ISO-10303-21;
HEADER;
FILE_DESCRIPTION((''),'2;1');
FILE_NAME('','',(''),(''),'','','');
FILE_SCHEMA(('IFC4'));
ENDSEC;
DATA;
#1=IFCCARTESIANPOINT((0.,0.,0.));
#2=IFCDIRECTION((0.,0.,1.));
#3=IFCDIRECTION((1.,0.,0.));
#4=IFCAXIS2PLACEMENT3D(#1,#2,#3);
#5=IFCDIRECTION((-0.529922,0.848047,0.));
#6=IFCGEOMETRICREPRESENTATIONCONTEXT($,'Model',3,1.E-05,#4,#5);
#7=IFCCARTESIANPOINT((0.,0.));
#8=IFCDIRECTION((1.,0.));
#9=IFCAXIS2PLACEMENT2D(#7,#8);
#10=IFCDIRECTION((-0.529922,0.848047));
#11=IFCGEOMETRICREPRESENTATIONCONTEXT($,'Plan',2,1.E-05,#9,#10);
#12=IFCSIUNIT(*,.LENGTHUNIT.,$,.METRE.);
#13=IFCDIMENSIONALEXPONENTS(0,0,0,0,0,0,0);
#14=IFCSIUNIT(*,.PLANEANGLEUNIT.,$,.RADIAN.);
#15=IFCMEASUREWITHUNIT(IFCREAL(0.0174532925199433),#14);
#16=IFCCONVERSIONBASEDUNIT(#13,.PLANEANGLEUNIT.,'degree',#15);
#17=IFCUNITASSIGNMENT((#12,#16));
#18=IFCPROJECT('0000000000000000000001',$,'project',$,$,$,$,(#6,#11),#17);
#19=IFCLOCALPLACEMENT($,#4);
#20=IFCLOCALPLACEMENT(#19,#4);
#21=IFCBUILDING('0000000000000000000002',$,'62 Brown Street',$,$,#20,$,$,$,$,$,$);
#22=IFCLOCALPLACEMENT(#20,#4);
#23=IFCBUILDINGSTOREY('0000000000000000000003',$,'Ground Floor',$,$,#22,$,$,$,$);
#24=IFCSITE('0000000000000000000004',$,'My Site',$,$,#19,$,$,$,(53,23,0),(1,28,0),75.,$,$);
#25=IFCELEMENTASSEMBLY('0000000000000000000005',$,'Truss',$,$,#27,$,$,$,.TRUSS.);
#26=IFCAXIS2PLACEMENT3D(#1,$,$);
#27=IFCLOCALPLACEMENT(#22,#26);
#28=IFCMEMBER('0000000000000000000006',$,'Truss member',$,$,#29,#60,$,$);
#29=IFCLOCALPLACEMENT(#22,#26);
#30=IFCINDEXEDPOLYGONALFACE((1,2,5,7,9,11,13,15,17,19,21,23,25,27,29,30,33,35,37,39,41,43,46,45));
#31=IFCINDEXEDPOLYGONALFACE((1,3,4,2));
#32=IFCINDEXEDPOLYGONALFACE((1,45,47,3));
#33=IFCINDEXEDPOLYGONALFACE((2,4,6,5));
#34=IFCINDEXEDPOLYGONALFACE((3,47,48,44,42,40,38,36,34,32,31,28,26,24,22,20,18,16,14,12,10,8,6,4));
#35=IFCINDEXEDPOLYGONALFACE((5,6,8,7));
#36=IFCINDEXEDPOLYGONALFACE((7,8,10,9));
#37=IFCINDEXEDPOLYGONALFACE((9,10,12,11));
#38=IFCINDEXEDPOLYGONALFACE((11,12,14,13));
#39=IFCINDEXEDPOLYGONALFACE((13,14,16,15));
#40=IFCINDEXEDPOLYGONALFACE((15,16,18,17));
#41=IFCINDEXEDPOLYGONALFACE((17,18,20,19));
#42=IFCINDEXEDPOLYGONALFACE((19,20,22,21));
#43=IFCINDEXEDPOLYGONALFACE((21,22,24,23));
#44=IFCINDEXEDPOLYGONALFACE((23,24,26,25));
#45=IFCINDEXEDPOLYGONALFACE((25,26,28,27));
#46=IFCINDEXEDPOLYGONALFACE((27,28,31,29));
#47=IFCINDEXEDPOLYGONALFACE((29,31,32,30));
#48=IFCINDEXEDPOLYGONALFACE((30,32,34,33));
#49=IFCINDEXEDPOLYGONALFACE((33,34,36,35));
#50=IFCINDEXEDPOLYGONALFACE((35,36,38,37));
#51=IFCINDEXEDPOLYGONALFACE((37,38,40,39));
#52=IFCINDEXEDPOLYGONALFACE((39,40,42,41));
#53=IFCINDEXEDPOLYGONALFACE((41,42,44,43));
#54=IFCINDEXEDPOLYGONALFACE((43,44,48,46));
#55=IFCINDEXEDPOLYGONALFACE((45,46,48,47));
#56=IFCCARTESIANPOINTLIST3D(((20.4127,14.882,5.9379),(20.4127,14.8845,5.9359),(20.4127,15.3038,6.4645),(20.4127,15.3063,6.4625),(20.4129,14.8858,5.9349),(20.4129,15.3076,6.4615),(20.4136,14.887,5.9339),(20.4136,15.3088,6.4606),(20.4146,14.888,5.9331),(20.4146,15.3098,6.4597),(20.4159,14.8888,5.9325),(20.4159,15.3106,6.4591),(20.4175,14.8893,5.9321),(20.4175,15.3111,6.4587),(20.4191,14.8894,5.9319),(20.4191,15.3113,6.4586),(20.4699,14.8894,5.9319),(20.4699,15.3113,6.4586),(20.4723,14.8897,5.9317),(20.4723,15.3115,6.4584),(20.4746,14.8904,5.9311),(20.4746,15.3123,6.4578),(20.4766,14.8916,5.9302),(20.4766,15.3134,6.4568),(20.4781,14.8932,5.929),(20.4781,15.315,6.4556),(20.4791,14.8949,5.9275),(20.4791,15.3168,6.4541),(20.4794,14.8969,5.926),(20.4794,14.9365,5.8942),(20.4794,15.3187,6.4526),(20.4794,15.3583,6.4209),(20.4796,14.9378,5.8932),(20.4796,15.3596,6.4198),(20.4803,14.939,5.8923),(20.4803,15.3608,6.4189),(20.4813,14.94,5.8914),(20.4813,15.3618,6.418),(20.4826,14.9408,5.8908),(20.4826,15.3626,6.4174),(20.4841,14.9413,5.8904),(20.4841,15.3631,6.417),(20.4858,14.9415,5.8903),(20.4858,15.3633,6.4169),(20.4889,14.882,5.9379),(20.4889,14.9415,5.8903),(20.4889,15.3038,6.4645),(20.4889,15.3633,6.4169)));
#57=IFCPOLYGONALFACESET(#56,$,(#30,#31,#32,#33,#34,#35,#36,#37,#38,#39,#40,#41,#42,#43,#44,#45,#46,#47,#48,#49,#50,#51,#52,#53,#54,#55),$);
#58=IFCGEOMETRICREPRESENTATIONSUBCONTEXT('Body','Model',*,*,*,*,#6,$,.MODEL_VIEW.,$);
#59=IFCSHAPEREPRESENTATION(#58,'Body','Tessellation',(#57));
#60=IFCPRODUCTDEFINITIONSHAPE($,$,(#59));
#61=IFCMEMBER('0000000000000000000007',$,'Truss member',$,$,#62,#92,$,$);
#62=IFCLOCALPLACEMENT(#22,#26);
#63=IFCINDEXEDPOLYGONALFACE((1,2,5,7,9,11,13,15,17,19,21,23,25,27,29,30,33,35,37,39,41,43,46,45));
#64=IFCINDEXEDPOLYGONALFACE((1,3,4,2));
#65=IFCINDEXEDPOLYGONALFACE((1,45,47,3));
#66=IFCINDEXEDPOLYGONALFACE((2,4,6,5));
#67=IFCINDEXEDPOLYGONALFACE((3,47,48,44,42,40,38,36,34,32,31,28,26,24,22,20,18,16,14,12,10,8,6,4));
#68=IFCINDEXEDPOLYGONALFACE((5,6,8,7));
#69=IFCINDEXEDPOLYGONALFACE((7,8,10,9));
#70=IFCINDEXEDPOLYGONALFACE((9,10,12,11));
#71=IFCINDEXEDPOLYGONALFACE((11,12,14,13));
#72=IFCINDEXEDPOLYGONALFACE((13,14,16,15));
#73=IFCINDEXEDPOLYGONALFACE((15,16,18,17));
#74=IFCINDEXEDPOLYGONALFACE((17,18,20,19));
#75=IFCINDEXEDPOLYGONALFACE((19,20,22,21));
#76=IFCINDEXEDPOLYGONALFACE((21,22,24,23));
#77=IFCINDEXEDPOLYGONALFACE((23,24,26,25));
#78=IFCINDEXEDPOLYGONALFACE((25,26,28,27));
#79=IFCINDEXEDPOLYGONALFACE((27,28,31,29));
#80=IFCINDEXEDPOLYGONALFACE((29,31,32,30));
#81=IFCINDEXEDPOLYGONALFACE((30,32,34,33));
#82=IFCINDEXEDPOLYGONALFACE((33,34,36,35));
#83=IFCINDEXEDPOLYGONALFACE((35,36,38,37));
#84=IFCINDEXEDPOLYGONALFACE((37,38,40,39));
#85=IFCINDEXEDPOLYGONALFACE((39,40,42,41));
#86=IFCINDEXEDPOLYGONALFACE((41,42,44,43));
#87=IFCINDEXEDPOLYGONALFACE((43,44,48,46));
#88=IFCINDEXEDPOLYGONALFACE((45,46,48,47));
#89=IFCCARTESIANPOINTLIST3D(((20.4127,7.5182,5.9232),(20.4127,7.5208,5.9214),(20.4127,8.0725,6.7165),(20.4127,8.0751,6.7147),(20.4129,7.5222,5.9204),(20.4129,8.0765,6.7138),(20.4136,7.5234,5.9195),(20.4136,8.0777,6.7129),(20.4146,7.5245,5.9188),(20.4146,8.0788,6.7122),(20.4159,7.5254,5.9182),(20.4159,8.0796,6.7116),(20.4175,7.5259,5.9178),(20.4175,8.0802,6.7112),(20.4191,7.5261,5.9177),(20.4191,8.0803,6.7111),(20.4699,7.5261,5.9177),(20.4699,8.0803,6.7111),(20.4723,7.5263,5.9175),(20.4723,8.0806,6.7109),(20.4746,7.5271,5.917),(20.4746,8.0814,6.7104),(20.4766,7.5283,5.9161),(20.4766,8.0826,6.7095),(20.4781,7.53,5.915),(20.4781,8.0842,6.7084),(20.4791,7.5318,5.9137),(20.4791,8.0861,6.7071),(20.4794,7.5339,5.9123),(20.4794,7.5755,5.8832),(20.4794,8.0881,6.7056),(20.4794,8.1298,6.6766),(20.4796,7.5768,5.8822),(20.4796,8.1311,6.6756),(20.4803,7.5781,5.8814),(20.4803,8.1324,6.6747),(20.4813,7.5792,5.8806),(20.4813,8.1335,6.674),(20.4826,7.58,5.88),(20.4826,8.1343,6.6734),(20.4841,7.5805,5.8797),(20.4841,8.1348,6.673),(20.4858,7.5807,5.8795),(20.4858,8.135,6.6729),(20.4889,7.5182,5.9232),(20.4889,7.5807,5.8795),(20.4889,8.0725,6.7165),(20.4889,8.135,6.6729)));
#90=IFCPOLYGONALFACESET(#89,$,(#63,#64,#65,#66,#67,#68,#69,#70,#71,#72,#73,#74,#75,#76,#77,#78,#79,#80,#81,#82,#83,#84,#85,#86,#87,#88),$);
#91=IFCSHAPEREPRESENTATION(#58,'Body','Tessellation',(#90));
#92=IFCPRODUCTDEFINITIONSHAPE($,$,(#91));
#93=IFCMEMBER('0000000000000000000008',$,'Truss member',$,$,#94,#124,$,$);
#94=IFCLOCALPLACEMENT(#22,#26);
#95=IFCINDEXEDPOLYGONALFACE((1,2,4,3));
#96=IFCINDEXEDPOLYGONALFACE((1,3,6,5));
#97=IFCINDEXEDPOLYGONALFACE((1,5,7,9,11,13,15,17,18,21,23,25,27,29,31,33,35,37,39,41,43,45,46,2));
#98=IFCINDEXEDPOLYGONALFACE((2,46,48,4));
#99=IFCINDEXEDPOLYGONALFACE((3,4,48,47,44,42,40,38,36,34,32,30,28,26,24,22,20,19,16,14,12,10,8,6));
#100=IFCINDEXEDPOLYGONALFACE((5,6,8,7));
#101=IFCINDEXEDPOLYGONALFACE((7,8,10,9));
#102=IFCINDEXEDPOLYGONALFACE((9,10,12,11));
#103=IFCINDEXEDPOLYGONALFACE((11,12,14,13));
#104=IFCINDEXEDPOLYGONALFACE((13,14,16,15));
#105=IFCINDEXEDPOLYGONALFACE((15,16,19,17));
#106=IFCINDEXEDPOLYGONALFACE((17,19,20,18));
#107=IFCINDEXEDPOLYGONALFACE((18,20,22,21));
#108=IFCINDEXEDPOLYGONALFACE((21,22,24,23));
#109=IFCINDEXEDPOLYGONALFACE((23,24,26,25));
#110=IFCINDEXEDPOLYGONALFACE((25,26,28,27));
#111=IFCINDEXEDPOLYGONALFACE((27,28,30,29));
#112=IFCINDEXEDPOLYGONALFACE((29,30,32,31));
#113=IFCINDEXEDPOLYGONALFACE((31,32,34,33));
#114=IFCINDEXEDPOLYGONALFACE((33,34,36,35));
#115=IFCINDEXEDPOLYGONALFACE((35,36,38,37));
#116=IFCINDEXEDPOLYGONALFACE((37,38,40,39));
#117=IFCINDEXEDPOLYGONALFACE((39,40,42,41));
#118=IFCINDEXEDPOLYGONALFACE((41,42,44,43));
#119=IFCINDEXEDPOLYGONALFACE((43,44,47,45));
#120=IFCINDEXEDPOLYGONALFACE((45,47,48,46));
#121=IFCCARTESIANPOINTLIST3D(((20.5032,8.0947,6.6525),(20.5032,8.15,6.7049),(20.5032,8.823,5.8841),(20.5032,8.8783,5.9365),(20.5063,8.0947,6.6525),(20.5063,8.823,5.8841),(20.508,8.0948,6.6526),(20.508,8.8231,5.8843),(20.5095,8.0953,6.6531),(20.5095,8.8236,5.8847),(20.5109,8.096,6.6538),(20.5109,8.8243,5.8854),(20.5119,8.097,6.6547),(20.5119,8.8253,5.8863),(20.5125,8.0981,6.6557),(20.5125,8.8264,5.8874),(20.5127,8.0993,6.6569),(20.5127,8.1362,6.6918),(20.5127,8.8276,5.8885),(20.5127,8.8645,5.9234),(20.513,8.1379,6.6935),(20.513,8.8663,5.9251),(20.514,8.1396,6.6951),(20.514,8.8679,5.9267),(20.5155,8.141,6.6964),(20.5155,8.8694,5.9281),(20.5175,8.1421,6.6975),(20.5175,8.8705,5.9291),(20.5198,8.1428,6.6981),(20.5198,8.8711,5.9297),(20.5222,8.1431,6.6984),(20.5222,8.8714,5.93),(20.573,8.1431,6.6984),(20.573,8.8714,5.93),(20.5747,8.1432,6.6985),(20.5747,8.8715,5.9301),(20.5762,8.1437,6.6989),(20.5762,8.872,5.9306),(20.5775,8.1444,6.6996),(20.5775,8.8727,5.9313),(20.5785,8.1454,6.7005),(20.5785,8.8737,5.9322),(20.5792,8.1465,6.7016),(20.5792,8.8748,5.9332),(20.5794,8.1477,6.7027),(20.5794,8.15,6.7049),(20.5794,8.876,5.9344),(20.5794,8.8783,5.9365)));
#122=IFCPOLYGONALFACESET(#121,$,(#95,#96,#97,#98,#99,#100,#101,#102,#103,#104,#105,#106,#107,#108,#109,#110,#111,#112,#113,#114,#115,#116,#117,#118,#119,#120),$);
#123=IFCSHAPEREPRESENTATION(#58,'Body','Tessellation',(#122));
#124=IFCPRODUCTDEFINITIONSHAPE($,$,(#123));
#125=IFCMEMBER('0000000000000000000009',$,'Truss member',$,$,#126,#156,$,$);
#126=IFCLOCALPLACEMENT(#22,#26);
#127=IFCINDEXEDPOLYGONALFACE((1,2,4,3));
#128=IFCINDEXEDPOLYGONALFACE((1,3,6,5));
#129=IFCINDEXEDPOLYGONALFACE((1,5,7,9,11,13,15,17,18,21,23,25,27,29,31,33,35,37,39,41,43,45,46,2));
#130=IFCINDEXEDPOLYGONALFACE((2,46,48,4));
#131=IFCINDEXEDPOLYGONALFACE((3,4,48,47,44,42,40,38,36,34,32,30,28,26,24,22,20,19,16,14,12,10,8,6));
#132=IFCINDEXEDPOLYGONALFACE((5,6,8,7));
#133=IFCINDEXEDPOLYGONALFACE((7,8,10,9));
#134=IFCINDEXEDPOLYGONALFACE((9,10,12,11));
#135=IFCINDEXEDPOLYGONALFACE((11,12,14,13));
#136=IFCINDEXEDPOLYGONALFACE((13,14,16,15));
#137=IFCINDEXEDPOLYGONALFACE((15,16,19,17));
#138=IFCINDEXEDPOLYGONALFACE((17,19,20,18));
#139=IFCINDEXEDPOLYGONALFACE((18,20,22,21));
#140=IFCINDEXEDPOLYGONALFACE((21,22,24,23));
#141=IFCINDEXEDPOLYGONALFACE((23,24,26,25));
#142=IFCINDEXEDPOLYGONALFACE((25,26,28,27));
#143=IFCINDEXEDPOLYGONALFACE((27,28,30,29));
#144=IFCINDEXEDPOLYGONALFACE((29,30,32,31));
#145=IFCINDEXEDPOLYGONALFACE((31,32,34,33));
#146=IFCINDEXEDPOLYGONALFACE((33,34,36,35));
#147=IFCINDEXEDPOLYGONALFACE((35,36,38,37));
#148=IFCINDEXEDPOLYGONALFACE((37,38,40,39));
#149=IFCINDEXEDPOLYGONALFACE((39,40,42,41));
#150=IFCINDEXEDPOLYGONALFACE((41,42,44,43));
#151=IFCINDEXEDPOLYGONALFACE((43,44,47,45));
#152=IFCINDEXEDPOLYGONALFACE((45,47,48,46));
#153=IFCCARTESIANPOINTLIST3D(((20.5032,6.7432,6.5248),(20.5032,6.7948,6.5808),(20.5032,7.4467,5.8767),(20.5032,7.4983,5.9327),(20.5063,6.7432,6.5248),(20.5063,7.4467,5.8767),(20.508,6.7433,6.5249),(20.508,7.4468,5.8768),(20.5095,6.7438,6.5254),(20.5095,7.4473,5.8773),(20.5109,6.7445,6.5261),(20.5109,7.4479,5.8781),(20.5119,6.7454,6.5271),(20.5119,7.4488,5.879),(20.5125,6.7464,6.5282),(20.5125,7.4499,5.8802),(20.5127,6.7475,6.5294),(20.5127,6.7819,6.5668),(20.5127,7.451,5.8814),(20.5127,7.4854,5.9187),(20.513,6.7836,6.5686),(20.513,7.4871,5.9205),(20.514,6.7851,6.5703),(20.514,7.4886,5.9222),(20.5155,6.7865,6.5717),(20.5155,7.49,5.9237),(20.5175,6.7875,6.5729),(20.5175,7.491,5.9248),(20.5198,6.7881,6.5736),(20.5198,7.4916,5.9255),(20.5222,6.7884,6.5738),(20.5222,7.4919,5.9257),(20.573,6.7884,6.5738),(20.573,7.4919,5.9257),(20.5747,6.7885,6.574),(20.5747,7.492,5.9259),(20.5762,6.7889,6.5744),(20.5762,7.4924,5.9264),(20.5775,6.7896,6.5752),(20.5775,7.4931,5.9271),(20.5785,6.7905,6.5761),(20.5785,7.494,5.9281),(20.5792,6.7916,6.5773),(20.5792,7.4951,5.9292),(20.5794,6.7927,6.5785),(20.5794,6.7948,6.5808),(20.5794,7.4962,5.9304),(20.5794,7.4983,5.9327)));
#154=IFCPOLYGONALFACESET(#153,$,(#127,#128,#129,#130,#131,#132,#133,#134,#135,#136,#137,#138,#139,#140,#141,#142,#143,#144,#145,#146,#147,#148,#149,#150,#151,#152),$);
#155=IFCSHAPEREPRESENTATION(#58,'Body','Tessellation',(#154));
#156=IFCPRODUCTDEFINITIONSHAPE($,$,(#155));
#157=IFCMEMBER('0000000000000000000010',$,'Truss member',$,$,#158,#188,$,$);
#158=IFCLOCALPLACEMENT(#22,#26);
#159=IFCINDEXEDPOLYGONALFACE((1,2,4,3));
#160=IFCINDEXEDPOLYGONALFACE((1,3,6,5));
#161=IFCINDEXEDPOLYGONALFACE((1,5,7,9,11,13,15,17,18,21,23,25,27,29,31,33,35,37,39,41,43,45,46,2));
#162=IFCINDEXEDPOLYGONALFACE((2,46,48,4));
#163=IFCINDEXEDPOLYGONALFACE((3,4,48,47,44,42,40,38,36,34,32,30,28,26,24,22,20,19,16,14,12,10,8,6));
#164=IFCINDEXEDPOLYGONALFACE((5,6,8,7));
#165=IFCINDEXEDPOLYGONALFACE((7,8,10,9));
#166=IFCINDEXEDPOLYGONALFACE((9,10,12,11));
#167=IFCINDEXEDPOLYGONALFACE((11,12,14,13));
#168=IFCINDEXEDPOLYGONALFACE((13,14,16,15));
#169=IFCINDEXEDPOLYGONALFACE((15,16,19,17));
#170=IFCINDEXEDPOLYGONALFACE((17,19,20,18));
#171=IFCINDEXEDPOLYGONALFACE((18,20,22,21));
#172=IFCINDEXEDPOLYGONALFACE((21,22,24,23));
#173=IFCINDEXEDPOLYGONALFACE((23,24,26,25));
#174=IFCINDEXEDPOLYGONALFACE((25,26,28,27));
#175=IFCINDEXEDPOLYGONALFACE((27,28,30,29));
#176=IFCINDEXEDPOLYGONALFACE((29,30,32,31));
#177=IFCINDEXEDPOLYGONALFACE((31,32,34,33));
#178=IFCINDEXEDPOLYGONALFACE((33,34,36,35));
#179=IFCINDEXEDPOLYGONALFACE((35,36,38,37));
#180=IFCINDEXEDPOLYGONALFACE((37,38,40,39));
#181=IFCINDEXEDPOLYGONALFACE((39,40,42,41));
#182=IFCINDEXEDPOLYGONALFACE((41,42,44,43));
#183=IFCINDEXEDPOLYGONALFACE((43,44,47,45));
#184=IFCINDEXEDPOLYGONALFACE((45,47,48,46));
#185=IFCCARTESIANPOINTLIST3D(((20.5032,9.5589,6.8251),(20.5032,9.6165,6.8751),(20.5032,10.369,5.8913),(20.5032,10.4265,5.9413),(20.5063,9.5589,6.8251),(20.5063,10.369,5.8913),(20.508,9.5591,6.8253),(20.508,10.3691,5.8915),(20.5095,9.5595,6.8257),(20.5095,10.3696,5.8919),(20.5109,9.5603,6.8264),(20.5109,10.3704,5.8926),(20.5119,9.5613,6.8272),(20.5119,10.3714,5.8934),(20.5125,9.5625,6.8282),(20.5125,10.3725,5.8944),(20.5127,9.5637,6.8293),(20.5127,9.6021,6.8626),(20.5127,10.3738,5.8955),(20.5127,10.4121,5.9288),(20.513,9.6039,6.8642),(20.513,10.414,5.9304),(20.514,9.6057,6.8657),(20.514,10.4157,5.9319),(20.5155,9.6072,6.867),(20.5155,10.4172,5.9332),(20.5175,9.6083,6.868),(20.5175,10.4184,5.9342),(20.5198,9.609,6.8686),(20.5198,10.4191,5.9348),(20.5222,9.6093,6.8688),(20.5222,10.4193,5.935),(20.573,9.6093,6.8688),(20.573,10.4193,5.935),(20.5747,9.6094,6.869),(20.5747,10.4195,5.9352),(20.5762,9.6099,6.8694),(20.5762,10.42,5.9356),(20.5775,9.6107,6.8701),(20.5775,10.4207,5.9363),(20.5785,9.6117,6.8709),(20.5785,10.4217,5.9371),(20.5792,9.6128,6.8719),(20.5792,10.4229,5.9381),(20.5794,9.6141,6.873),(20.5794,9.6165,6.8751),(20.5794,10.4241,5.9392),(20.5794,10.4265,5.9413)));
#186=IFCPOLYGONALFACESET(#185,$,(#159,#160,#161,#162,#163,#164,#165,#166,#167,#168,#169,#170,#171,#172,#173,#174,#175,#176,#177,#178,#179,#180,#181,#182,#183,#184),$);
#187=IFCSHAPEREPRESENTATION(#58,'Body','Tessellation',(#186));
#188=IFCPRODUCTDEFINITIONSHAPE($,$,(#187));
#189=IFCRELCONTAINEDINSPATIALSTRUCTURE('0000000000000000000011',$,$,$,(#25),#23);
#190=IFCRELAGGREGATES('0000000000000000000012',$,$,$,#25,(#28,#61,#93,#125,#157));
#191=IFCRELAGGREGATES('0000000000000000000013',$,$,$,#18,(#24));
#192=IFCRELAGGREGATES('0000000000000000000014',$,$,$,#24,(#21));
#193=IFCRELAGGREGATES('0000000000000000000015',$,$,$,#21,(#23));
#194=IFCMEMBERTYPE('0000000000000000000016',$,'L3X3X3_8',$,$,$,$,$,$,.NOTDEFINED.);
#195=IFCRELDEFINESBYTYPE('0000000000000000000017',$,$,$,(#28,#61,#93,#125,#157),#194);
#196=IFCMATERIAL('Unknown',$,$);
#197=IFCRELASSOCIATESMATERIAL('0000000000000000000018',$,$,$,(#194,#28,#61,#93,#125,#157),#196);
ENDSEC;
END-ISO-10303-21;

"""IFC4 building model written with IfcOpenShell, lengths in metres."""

from ifc_helpers import new_model, entity, si_unit, converted_unit, direction, frame, origin_with_axes, origin_2d_with_axis, place, context, subcontext, project, spatial, l_section, extrude, material, material_profile, profile_set, profile_usage, type_object, element, aggregate, save


model = new_model("IFC4")

# Units and contexts
model_context = context("Model", 3, precision=1e-05, world=origin_with_axes(), true_north=direction((-0.529922, 0.848047, 0.0)))
plan_context = context("Plan", 2, precision=1e-05, world=origin_2d_with_axis(), true_north=direction((-0.529922, 0.848047)))
body_context_1 = subcontext(model_context, "Body", "Model", "MODEL_VIEW")
ifc_project = project(units=[si_unit("LENGTHUNIT", "METRE"), converted_unit("PLANEANGLEUNIT", "degree", entity("IfcReal", 0.0174532925199433), si_unit("PLANEANGLEUNIT", "RADIAN"), dimensions=[0, 0, 0, 0, 0, 0, 0])], contexts=[model_context, plan_context])

# Site, building, storey
site_placement = place(None, origin_with_axes())
site = spatial("IfcSite", under=ifc_project, at=site_placement, Name="My Site", RefLatitude=(53, 23, 0), RefLongitude=(1, 28, 0), RefElevation=75.0)
building_placement = place(site_placement, origin_with_axes())
building = spatial("IfcBuilding", under=site, at=building_placement, Name="62 Brown Street")
storey_placement = place(building_placement, origin_with_axes())
storey = spatial("IfcBuildingStorey", under=building, at=storey_placement, Name="Ground Floor")

# Element assembly, members
assembly_placement = place(storey_placement, frame((20.5032, 10.4288, 6.9738), z_axis=(0.0, 0.0, 1.0), x_axis=(1.0, 0.0, 0.0)))
assembly = element("IfcElementAssembly", 1, at=assembly_placement, inside=storey, Name="Truss", PredefinedType="TRUSS")
ifc_material_1 = material(Name="Unknown")
ifc_material_profile_1 = material_profile(ifc_material_1, l_section(Depth=0.0762, Width=0.0762, Thickness=0.0095, FilletRadius=0.0095, EdgeRadius=0.0064))
ifc_profile_set_1 = profile_set([ifc_material_profile_1])
member_type_1 = type_object("IfcMemberType", Name="L3X3X3_8", PredefinedType="NOTDEFINED", material=ifc_profile_set_1)
ifc_profile_usage_1 = profile_usage(ifc_profile_set_1, cardinal=5)
member_1_placement = place(assembly_placement, frame((-0.0524, 4.9048, -0.5331), z_axis=(0.000001, -0.625169, -0.780489), x_axis=(-1.0, -0.000001, 0.0)))
member_1 = element("IfcMember", 2, at=member_1_placement, type_object=member_type_1, material=ifc_profile_usage_1, Name="Truss member", context=body_context_1, shape_type="SweptSolid", body=[
    extrude(l_section(Depth=0.0762, Width=0.0762, Thickness=0.0095, FilletRadius=0.0095, EdgeRadius=0.0064), origin_with_axes(), (0.0, 0.0, 1.0), 0.6747),
])
ifc_profile_usage_2 = profile_usage(ifc_profile_set_1, cardinal=5)
member_2_placement = place(assembly_placement, frame((-0.0524, -2.325, -0.279), z_axis=(0.000001, -0.572709, -0.819759), x_axis=(-1.0, -0.000001, 0.0)))
member_2 = element("IfcMember", 3, at=member_2_placement, type_object=member_type_1, material=ifc_profile_usage_2, Name="Truss member", context=body_context_1, shape_type="SweptSolid", body=[
    extrude(l_section(Depth=0.0762, Width=0.0762, Thickness=0.0095, FilletRadius=0.0095, EdgeRadius=0.0064), origin_with_axes(), (0.0, 0.0, 1.0), 0.9678),
])
ifc_profile_usage_3 = profile_usage(ifc_profile_set_1, cardinal=5)
member_3_placement = place(assembly_placement, frame((0.0381, -2.3065, -0.2951), z_axis=(-0.000001, 0.687927, -0.72578), x_axis=(1.0, 0.0, 0.0)))
member_3 = element("IfcMember", 4, at=member_3_placement, type_object=member_type_1, material=ifc_profile_usage_3, Name="Truss member", context=body_context_1, shape_type="SweptSolid", body=[
    extrude(l_section(Depth=0.0762, Width=0.0762, Thickness=0.0095, FilletRadius=0.0095, EdgeRadius=0.0064), origin_with_axes(), (0.0, 0.0, 1.0), 1.0587),
])
ifc_profile_usage_4 = profile_usage(ifc_profile_set_1, cardinal=5)
member_4_placement = place(assembly_placement, frame((0.0381, -3.6598, -0.421), z_axis=(-0.000001, 0.735484, -0.677542), x_axis=(1.0, 0.000001, 0.0)))
member_4 = element("IfcMember", 5, at=member_4_placement, type_object=member_type_1, material=ifc_profile_usage_4, Name="Truss member", context=body_context_1, shape_type="SweptSolid", body=[
    extrude(l_section(Depth=0.0762, Width=0.0762, Thickness=0.0095, FilletRadius=0.0095, EdgeRadius=0.0064), origin_with_axes(), (0.0, 0.0, 1.0), 0.9565),
])
ifc_profile_usage_5 = profile_usage(ifc_profile_set_1, cardinal=5)
member_5_placement = place(assembly_placement, frame((0.0381, -0.8411, -0.1236), z_axis=(-0.000001, 0.655276, -0.755389), x_axis=(1.0, 0.000001, 0.0)))
member_5 = element("IfcMember", 6, at=member_5_placement, type_object=member_type_1, material=ifc_profile_usage_5, Name="Truss member", context=body_context_1, shape_type="SweptSolid", body=[
    extrude(l_section(Depth=0.0762, Width=0.0762, Thickness=0.0095, FilletRadius=0.0095, EdgeRadius=0.0064), origin_with_axes(), (0.0, 0.0, 1.0), 1.2362),
])

aggregate(assembly, [member_1, member_2, member_3, member_4, member_5])

save(model, "model.ifc")
